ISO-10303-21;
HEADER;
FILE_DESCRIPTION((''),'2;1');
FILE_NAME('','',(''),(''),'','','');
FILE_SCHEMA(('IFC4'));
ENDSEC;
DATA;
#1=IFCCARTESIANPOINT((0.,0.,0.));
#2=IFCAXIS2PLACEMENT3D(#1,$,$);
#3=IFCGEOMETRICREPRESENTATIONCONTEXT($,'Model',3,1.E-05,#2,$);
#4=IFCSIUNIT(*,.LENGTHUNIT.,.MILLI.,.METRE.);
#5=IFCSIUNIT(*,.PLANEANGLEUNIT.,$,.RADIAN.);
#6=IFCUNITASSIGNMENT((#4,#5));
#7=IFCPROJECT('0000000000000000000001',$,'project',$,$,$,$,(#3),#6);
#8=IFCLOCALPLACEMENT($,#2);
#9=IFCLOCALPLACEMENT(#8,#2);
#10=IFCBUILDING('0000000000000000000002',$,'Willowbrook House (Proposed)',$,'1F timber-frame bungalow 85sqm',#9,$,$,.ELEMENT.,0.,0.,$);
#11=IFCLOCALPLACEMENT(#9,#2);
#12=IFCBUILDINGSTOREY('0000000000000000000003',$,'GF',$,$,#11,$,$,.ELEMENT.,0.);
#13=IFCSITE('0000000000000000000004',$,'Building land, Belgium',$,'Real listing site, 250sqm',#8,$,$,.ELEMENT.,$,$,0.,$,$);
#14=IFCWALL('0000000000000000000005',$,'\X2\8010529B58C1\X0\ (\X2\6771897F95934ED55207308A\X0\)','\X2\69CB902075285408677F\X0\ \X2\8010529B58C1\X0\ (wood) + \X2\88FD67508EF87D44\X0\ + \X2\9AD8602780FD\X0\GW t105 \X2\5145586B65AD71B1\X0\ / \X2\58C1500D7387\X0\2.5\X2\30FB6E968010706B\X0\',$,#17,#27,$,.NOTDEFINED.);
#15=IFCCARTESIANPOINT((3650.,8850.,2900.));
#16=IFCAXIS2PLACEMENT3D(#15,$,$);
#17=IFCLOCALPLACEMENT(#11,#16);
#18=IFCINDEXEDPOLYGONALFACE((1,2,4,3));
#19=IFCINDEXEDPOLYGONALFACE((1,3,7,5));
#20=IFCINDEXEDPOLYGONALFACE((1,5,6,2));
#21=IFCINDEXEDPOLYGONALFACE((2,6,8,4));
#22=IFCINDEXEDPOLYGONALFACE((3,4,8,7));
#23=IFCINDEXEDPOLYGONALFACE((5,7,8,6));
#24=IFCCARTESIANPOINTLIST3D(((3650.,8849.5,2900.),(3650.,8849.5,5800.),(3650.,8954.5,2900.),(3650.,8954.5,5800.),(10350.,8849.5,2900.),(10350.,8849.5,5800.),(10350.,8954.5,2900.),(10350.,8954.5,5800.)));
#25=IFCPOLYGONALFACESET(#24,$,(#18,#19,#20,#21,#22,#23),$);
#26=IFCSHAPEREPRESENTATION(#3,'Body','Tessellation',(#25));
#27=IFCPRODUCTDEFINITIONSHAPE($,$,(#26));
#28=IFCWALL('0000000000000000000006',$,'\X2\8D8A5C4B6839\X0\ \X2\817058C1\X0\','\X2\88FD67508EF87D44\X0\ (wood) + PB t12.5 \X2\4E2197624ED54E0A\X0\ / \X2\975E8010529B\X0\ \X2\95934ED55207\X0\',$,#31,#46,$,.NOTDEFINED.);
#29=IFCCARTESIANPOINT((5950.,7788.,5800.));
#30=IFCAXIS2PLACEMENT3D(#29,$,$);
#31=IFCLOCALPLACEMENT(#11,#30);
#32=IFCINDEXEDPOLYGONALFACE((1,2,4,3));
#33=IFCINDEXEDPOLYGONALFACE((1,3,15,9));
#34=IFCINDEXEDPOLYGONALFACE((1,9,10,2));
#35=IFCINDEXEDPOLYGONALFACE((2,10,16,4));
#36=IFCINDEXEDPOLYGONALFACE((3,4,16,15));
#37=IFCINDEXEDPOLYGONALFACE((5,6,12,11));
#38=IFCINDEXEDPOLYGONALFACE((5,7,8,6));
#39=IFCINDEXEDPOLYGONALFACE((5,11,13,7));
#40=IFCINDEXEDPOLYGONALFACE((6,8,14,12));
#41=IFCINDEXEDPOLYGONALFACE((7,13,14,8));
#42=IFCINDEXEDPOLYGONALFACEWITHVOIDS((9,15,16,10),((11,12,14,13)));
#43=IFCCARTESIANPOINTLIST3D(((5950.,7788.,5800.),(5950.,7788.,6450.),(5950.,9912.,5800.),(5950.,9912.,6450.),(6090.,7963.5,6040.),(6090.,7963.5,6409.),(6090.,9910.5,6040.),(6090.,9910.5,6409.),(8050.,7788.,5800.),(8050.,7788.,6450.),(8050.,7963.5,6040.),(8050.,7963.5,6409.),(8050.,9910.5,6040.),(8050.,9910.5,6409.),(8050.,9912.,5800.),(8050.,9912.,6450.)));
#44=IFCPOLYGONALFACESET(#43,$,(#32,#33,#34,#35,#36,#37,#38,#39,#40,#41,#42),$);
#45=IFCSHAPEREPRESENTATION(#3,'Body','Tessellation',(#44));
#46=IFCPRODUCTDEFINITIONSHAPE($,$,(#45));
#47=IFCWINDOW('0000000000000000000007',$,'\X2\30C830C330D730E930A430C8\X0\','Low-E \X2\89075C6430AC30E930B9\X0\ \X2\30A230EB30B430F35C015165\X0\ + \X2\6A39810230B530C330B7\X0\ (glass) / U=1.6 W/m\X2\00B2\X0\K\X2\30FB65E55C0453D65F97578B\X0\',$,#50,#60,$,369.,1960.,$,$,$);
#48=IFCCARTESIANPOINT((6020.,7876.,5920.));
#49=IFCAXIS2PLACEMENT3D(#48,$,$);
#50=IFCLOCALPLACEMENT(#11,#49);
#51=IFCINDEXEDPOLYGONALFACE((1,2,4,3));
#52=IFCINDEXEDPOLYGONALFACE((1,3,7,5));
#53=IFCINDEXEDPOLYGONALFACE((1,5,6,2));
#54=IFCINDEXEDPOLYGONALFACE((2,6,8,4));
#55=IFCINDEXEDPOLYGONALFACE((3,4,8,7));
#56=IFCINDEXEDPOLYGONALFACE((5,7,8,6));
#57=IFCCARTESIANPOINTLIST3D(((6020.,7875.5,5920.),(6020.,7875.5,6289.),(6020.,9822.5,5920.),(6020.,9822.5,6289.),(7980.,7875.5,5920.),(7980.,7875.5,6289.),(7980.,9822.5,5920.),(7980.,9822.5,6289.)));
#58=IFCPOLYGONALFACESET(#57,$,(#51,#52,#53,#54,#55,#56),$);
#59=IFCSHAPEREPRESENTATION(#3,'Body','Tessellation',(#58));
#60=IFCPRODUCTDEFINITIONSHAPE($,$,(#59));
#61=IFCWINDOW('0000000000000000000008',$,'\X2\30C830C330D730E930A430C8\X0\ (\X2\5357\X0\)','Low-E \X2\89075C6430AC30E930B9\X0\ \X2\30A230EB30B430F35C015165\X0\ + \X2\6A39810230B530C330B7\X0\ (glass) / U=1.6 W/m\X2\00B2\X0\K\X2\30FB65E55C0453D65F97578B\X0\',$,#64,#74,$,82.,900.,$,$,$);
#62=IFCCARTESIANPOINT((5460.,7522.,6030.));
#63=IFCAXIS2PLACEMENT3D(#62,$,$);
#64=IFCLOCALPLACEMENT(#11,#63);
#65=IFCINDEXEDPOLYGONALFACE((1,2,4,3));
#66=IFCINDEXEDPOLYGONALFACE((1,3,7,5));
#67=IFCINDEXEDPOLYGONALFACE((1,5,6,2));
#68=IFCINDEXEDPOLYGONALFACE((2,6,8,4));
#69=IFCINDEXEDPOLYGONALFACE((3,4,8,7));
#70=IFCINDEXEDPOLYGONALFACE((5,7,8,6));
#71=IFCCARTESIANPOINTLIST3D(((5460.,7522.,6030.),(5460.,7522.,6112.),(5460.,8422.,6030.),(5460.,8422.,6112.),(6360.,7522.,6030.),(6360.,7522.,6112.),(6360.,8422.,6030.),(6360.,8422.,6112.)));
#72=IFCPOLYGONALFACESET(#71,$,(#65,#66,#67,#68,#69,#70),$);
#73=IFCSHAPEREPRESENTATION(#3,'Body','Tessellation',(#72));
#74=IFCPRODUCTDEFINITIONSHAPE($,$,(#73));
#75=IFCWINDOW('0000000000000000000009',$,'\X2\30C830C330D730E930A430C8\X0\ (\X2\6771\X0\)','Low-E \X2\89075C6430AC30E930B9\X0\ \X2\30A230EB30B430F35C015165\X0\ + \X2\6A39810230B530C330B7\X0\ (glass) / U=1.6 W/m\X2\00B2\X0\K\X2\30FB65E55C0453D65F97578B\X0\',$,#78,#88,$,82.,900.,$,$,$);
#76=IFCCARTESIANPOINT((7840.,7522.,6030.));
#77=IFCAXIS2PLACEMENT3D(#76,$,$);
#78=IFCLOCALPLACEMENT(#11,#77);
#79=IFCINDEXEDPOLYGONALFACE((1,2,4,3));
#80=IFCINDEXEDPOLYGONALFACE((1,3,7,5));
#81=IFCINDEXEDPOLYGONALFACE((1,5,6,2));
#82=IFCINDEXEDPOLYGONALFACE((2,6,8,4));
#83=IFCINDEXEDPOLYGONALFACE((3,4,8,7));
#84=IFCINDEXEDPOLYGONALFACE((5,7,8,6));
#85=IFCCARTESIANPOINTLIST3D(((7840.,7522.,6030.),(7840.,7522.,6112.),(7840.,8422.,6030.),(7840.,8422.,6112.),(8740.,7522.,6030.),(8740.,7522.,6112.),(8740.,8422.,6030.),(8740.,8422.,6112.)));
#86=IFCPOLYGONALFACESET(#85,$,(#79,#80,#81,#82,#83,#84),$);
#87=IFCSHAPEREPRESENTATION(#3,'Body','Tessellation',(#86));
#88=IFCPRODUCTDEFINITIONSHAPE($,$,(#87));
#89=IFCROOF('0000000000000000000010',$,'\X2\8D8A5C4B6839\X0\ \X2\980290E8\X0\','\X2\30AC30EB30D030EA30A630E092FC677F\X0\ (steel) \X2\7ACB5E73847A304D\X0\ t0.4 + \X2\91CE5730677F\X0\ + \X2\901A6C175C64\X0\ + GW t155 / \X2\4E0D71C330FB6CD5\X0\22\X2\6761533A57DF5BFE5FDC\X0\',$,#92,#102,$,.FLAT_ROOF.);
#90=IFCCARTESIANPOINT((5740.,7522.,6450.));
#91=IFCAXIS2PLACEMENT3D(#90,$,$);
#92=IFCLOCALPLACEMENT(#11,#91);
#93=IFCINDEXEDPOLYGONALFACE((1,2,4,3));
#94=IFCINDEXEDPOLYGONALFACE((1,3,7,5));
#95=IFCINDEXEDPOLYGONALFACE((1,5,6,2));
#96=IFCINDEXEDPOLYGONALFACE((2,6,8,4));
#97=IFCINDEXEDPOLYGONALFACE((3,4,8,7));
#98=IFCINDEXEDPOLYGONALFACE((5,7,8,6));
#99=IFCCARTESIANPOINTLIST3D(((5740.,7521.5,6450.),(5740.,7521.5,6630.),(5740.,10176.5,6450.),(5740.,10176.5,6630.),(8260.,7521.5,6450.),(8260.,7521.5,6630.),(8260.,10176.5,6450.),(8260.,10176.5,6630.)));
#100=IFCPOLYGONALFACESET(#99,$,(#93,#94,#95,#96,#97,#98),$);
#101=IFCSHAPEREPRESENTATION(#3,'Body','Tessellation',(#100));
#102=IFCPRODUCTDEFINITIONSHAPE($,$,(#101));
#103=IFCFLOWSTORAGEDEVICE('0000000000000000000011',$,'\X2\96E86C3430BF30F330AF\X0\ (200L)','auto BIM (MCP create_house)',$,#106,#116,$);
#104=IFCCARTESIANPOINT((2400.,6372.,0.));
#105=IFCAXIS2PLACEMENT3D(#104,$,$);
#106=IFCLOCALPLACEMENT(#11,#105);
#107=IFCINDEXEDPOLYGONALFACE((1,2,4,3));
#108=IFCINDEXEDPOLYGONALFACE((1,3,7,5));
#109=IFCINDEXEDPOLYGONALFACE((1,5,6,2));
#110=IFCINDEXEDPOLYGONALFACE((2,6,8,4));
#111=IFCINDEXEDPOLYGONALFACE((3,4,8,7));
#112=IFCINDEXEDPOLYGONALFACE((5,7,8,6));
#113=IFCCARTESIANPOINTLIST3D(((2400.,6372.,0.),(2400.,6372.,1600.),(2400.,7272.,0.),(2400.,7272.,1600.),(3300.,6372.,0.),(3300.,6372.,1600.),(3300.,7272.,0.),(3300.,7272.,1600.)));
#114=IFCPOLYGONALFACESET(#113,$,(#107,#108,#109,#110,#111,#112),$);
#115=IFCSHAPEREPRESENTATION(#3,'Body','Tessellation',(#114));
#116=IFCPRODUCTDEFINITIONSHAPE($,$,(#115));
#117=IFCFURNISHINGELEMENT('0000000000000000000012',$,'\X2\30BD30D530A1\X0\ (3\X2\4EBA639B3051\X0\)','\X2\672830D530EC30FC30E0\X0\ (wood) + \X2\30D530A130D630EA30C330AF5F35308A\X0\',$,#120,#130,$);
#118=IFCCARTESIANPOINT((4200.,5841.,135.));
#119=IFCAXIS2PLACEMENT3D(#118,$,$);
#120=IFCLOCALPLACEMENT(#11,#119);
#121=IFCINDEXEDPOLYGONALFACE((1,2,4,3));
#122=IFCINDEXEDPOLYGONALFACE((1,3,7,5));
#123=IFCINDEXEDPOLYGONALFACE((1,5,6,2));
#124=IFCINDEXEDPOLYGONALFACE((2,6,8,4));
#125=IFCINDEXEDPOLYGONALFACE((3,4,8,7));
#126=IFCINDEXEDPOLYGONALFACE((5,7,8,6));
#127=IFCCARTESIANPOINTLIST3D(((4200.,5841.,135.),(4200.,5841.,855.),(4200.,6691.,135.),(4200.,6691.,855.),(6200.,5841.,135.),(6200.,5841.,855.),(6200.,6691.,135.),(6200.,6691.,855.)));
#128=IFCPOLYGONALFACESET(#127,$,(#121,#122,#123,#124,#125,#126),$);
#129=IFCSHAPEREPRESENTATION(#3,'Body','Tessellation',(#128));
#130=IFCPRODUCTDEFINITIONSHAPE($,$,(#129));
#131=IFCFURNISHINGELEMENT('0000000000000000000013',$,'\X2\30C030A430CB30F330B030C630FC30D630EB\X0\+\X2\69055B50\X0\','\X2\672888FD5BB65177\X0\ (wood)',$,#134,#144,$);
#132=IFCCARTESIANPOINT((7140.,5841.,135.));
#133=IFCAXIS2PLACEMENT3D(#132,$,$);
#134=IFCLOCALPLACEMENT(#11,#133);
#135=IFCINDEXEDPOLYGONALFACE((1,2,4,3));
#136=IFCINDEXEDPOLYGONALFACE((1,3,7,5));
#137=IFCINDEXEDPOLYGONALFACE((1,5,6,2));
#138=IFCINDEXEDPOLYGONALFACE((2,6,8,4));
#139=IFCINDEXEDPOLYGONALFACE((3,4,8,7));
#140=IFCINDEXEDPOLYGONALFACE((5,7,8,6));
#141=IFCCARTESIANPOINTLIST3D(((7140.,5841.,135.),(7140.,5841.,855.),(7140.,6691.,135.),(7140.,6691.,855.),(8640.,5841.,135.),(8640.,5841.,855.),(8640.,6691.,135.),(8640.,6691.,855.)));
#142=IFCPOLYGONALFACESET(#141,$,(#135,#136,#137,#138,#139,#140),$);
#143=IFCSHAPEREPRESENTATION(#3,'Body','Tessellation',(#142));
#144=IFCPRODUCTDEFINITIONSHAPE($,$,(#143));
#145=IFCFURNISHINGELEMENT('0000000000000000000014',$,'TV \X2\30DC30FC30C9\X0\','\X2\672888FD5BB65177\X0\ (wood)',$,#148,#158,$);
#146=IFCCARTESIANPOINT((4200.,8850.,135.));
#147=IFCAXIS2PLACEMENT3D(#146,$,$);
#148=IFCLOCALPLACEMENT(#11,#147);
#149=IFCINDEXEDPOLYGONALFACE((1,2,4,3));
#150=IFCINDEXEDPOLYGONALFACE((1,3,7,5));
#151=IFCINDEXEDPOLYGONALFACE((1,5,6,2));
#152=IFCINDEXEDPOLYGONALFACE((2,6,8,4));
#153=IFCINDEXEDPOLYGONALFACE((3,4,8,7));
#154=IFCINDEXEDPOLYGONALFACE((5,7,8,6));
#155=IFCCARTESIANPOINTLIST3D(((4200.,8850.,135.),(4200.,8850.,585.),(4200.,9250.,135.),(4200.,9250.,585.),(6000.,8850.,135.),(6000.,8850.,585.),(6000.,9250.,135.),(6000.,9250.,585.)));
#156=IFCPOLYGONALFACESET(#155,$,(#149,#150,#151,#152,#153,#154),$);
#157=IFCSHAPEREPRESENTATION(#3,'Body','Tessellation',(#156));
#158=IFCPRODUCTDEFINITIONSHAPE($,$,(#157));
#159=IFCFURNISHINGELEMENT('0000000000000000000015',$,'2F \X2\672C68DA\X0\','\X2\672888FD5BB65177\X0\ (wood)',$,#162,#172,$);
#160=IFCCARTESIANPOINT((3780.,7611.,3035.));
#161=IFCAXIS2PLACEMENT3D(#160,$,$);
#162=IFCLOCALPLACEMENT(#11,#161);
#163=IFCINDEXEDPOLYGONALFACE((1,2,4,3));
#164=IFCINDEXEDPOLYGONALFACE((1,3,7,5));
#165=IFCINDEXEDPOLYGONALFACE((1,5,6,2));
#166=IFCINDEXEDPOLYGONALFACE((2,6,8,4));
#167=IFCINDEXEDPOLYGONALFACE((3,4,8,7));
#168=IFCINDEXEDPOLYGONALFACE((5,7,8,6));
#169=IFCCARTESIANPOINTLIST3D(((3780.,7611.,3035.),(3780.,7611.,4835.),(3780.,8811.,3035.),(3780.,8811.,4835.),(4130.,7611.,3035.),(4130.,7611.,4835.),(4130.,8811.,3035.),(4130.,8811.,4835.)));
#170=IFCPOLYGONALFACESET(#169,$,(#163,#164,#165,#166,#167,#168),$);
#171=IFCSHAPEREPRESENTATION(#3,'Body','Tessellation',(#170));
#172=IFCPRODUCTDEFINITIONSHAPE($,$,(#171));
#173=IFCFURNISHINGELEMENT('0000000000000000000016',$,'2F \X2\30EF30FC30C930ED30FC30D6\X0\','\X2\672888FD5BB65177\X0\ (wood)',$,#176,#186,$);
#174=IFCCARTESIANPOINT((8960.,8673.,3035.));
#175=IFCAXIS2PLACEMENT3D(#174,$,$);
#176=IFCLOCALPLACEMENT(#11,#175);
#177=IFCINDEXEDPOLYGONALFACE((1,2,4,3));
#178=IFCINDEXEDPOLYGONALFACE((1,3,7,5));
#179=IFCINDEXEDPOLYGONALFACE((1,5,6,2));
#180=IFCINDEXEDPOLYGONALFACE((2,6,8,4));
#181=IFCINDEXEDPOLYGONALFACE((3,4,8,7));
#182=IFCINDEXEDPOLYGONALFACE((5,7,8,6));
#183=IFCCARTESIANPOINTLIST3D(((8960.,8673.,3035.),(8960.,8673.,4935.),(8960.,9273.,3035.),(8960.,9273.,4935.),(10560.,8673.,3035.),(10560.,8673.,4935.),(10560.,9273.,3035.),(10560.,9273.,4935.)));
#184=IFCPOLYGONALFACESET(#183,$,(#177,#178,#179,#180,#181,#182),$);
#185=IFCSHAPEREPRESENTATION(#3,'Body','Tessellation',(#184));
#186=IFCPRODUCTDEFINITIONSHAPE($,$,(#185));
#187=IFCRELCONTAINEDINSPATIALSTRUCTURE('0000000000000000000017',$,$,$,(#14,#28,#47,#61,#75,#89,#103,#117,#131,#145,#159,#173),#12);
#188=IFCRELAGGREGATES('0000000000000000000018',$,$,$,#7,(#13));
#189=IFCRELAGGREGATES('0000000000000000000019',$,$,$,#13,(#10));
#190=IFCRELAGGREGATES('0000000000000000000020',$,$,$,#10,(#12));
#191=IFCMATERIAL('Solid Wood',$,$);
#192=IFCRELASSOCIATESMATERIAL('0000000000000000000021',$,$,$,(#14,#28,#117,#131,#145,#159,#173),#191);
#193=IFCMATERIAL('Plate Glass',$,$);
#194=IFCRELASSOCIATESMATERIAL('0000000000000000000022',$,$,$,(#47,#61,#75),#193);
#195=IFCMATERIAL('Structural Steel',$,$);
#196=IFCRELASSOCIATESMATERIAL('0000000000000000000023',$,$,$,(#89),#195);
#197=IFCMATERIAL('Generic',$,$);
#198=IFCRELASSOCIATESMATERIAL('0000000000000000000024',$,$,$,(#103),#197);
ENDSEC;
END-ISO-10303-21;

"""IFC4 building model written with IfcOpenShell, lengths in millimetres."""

from ifc_helpers import new_model, si_unit, frame, frame_2d, origin, place, context, project, spatial, rectangle, extrude, material, element, fill, save


model = new_model("IFC4")

# Units and contexts
model_context = context("Model", 3, precision=1e-05, world=origin())
ifc_project = project(units=[si_unit("LENGTHUNIT", "METRE", prefix="MILLI"), si_unit("PLANEANGLEUNIT", "RADIAN")], contexts=[model_context])

# Site, building, storey
site_placement = place(None, origin())
site = spatial("IfcSite", under=ifc_project, at=site_placement, Name="Building land, Belgium", ObjectType="Real listing site, 250sqm", CompositionType="ELEMENT", RefElevation=0.0)
building_placement = place(site_placement, origin())
building = spatial("IfcBuilding", under=site, at=building_placement, Name="Willowbrook House (Proposed)", ObjectType="1F timber-frame bungalow 85sqm", CompositionType="ELEMENT", ElevationOfRefHeight=0.0, ElevationOfTerrain=0.0)
storey_placement = place(building_placement, origin())
storey = spatial("IfcBuildingStorey", under=building, at=storey_placement, Name="GF", CompositionType="ELEMENT", Elevation=0.0)

# Wall
ifc_material_1 = material(Name="Solid Wood")
wall_1_placement = place(storey_placement, frame((3650.0, 8850.0, 2900.0)))
element("IfcWall", 1, at=wall_1_placement, inside=storey, material=ifc_material_1, Name="耐力壁 (東西間仕切り)", Description="構造用合板 耐力壁 (wood) + 製材軸組 + 高性能GW t105 充填断熱 / 壁倍率2.5・準耐火", PredefinedType="NOTDEFINED", context=model_context, shape_type="SweptSolid", body=[
    extrude(rectangle(XDim=6700.0, YDim=105.0, at=frame_2d((3350.0, 52.0))), frame((3650.0, 8850.0, 2900.0)), (0.0, 0.0, 1.0), 2900.0),
])

# Wall, openings, windows
wall_2_placement = place(storey_placement, frame((5950.0, 7788.0, 5800.0)))
wall_2 = element("IfcWall", 2, at=wall_2_placement, inside=storey, material=ifc_material_1, Name="越屋根 腰壁", Description="製材軸組 (wood) + PB t12.5 両面仕上 / 非耐力 間仕切", PredefinedType="NOTDEFINED", context=model_context, shape_type="SweptSolid", body=[
    extrude(rectangle(XDim=2100.0, YDim=2124.0, at=frame_2d((1050.0, 1062.0))), frame((5950.0, 7788.0, 5800.0)), (0.0, 0.0, 1.0), 650.0),
])
opening_1_placement = place(storey_placement, frame((6020.0, 7876.0, 5920.0)))
opening_1 = element("IfcOpeningElement", 3, at=opening_1_placement, cuts=wall_2, PredefinedType="NOTDEFINED", context=model_context, shape_type="SweptSolid", body=[
    extrude(rectangle(XDim=1960.0, YDim=1947.0, at=frame_2d((980.0, 973.0))), frame((6020.0, 7876.0, 5920.0)), (0.0, 0.0, 1.0), 369.0),
])
opening_2_placement = place(storey_placement, frame((5460.0, 7522.0, 6030.0)))
opening_2 = element("IfcOpeningElement", 4, at=opening_2_placement, cuts=wall_2, PredefinedType="NOTDEFINED", context=model_context, shape_type="SweptSolid", body=[
    extrude(rectangle(XDim=900.0, YDim=900.0, at=frame_2d((450.0, 450.0))), frame((5460.0, 7522.0, 6030.0)), (0.0, 0.0, 1.0), 82.0),
])
opening_3_placement = place(storey_placement, frame((7840.0, 7522.0, 6030.0)))
opening_3 = element("IfcOpeningElement", 5, at=opening_3_placement, cuts=wall_2, PredefinedType="NOTDEFINED", context=model_context, shape_type="SweptSolid", body=[
    extrude(rectangle(XDim=900.0, YDim=900.0, at=frame_2d((450.0, 450.0))), frame((7840.0, 7522.0, 6030.0)), (0.0, 0.0, 1.0), 82.0),
])
ifc_material_2 = material(Name="Plate Glass")
window_1_placement = place(storey_placement, frame((6020.0, 7876.0, 5920.0)))
window_1 = element("IfcWindow", 6, at=window_1_placement, inside=storey, material=ifc_material_2, Name="トップライト", Description="Low-E 複層ガラス アルゴン封入 + 樹脂サッシ (glass) / U=1.6 W/m²K・日射取得型", OverallHeight=369.0, OverallWidth=1960.0, context=model_context, shape_type="SweptSolid", body=[
    extrude(rectangle(XDim=1960.0, YDim=1947.0, at=frame_2d((980.0, 973.0))), frame((6020.0, 7876.0, 5920.0)), (0.0, 0.0, 1.0), 369.0),
])
fill(opening_1, window_1)
window_2_placement = place(storey_placement, frame((5460.0, 7522.0, 6030.0)))
window_2 = element("IfcWindow", 7, at=window_2_placement, inside=storey, material=ifc_material_2, Name="トップライト (南)", Description="Low-E 複層ガラス アルゴン封入 + 樹脂サッシ (glass) / U=1.6 W/m²K・日射取得型", OverallHeight=82.0, OverallWidth=900.0, context=model_context, shape_type="SweptSolid", body=[
    extrude(rectangle(XDim=900.0, YDim=900.0, at=frame_2d((450.0, 450.0))), frame((5460.0, 7522.0, 6030.0)), (0.0, 0.0, 1.0), 82.0),
])
fill(opening_2, window_2)
window_3_placement = place(storey_placement, frame((7840.0, 7522.0, 6030.0)))
window_3 = element("IfcWindow", 8, at=window_3_placement, inside=storey, material=ifc_material_2, Name="トップライト (東)", Description="Low-E 複層ガラス アルゴン封入 + 樹脂サッシ (glass) / U=1.6 W/m²K・日射取得型", OverallHeight=82.0, OverallWidth=900.0, context=model_context, shape_type="SweptSolid", body=[
    extrude(rectangle(XDim=900.0, YDim=900.0, at=frame_2d((450.0, 450.0))), frame((7840.0, 7522.0, 6030.0)), (0.0, 0.0, 1.0), 82.0),
])
fill(opening_3, window_3)

# Roof
ifc_material_3 = material(Name="Structural Steel")
roof_placement = place(storey_placement, frame((5740.0, 7522.0, 6450.0)))
element("IfcRoof", 9, at=roof_placement, inside=storey, material=ifc_material_3, Name="越屋根 頂部", Description="ガルバリウム鋼板 (steel) 立平葺き t0.4 + 野地板 + 通気層 + GW t155 / 不燃・法22条区域対応", PredefinedType="FLAT_ROOF", context=model_context, shape_type="SweptSolid", body=[
    extrude(rectangle(XDim=2520.0, YDim=2655.0, at=frame_2d((1260.0, 1327.0))), frame((5740.0, 7522.0, 6450.0)), (0.0, 0.0, 1.0), 180.0),
])

# Flow storage device
ifc_material_4 = material(Name="Generic")
flow_storage_device_placement = place(storey_placement, frame((2400.0, 6372.0, 0.0)))
element("IfcFlowStorageDevice", 10, at=flow_storage_device_placement, inside=storey, material=ifc_material_4, Name="雨水タンク (200L)", Description="auto BIM (MCP create_house)", context=model_context, shape_type="SweptSolid", body=[
    extrude(rectangle(XDim=900.0, YDim=900.0, at=frame_2d((450.0, 450.0))), frame((2400.0, 6372.0, 0.0)), (0.0, 0.0, 1.0), 1600.0),
])

# Furnishing elements
furnishing_1_placement = place(storey_placement, frame((4200.0, 5841.0, 135.0)))
element("IfcFurnishingElement", 11, at=furnishing_1_placement, inside=storey, material=ifc_material_1, Name="ソファ (3人掛け)", Description="木フレーム (wood) + ファブリック張り", context=model_context, shape_type="SweptSolid", body=[
    extrude(rectangle(XDim=2000.0, YDim=850.0, at=frame_2d((1000.0, 425.0))), frame((4200.0, 5841.0, 135.0)), (0.0, 0.0, 1.0), 720.0),
])
furnishing_2_placement = place(storey_placement, frame((7140.0, 5841.0, 135.0)))
element("IfcFurnishingElement", 12, at=furnishing_2_placement, inside=storey, material=ifc_material_1, Name="ダイニングテーブル+椅子", Description="木製家具 (wood)", context=model_context, shape_type="SweptSolid", body=[
    extrude(rectangle(XDim=1500.0, YDim=850.0, at=frame_2d((750.0, 425.0))), frame((7140.0, 5841.0, 135.0)), (0.0, 0.0, 1.0), 720.0),
])
furnishing_3_placement = place(storey_placement, frame((4200.0, 8850.0, 135.0)))
element("IfcFurnishingElement", 13, at=furnishing_3_placement, inside=storey, material=ifc_material_1, Name="TV ボード", Description="木製家具 (wood)", context=model_context, shape_type="SweptSolid", body=[
    extrude(rectangle(XDim=1800.0, YDim=400.0, at=frame_2d((900.0, 200.0))), frame((4200.0, 8850.0, 135.0)), (0.0, 0.0, 1.0), 450.0),
])
furnishing_4_placement = place(storey_placement, frame((3780.0, 7611.0, 3035.0)))
element("IfcFurnishingElement", 14, at=furnishing_4_placement, inside=storey, material=ifc_material_1, Name="2F 本棚", Description="木製家具 (wood)", context=model_context, shape_type="SweptSolid", body=[
    extrude(rectangle(XDim=350.0, YDim=1200.0, at=frame_2d((175.0, 600.0))), frame((3780.0, 7611.0, 3035.0)), (0.0, 0.0, 1.0), 1800.0),
])
furnishing_5_placement = place(storey_placement, frame((8960.0, 8673.0, 3035.0)))
element("IfcFurnishingElement", 15, at=furnishing_5_placement, inside=storey, material=ifc_material_1, Name="2F ワードローブ", Description="木製家具 (wood)", context=model_context, shape_type="SweptSolid", body=[
    extrude(rectangle(XDim=1600.0, YDim=600.0, at=frame_2d((800.0, 300.0))), frame((8960.0, 8673.0, 3035.0)), (0.0, 0.0, 1.0), 1900.0),
])

save(model, "model.ifc")
